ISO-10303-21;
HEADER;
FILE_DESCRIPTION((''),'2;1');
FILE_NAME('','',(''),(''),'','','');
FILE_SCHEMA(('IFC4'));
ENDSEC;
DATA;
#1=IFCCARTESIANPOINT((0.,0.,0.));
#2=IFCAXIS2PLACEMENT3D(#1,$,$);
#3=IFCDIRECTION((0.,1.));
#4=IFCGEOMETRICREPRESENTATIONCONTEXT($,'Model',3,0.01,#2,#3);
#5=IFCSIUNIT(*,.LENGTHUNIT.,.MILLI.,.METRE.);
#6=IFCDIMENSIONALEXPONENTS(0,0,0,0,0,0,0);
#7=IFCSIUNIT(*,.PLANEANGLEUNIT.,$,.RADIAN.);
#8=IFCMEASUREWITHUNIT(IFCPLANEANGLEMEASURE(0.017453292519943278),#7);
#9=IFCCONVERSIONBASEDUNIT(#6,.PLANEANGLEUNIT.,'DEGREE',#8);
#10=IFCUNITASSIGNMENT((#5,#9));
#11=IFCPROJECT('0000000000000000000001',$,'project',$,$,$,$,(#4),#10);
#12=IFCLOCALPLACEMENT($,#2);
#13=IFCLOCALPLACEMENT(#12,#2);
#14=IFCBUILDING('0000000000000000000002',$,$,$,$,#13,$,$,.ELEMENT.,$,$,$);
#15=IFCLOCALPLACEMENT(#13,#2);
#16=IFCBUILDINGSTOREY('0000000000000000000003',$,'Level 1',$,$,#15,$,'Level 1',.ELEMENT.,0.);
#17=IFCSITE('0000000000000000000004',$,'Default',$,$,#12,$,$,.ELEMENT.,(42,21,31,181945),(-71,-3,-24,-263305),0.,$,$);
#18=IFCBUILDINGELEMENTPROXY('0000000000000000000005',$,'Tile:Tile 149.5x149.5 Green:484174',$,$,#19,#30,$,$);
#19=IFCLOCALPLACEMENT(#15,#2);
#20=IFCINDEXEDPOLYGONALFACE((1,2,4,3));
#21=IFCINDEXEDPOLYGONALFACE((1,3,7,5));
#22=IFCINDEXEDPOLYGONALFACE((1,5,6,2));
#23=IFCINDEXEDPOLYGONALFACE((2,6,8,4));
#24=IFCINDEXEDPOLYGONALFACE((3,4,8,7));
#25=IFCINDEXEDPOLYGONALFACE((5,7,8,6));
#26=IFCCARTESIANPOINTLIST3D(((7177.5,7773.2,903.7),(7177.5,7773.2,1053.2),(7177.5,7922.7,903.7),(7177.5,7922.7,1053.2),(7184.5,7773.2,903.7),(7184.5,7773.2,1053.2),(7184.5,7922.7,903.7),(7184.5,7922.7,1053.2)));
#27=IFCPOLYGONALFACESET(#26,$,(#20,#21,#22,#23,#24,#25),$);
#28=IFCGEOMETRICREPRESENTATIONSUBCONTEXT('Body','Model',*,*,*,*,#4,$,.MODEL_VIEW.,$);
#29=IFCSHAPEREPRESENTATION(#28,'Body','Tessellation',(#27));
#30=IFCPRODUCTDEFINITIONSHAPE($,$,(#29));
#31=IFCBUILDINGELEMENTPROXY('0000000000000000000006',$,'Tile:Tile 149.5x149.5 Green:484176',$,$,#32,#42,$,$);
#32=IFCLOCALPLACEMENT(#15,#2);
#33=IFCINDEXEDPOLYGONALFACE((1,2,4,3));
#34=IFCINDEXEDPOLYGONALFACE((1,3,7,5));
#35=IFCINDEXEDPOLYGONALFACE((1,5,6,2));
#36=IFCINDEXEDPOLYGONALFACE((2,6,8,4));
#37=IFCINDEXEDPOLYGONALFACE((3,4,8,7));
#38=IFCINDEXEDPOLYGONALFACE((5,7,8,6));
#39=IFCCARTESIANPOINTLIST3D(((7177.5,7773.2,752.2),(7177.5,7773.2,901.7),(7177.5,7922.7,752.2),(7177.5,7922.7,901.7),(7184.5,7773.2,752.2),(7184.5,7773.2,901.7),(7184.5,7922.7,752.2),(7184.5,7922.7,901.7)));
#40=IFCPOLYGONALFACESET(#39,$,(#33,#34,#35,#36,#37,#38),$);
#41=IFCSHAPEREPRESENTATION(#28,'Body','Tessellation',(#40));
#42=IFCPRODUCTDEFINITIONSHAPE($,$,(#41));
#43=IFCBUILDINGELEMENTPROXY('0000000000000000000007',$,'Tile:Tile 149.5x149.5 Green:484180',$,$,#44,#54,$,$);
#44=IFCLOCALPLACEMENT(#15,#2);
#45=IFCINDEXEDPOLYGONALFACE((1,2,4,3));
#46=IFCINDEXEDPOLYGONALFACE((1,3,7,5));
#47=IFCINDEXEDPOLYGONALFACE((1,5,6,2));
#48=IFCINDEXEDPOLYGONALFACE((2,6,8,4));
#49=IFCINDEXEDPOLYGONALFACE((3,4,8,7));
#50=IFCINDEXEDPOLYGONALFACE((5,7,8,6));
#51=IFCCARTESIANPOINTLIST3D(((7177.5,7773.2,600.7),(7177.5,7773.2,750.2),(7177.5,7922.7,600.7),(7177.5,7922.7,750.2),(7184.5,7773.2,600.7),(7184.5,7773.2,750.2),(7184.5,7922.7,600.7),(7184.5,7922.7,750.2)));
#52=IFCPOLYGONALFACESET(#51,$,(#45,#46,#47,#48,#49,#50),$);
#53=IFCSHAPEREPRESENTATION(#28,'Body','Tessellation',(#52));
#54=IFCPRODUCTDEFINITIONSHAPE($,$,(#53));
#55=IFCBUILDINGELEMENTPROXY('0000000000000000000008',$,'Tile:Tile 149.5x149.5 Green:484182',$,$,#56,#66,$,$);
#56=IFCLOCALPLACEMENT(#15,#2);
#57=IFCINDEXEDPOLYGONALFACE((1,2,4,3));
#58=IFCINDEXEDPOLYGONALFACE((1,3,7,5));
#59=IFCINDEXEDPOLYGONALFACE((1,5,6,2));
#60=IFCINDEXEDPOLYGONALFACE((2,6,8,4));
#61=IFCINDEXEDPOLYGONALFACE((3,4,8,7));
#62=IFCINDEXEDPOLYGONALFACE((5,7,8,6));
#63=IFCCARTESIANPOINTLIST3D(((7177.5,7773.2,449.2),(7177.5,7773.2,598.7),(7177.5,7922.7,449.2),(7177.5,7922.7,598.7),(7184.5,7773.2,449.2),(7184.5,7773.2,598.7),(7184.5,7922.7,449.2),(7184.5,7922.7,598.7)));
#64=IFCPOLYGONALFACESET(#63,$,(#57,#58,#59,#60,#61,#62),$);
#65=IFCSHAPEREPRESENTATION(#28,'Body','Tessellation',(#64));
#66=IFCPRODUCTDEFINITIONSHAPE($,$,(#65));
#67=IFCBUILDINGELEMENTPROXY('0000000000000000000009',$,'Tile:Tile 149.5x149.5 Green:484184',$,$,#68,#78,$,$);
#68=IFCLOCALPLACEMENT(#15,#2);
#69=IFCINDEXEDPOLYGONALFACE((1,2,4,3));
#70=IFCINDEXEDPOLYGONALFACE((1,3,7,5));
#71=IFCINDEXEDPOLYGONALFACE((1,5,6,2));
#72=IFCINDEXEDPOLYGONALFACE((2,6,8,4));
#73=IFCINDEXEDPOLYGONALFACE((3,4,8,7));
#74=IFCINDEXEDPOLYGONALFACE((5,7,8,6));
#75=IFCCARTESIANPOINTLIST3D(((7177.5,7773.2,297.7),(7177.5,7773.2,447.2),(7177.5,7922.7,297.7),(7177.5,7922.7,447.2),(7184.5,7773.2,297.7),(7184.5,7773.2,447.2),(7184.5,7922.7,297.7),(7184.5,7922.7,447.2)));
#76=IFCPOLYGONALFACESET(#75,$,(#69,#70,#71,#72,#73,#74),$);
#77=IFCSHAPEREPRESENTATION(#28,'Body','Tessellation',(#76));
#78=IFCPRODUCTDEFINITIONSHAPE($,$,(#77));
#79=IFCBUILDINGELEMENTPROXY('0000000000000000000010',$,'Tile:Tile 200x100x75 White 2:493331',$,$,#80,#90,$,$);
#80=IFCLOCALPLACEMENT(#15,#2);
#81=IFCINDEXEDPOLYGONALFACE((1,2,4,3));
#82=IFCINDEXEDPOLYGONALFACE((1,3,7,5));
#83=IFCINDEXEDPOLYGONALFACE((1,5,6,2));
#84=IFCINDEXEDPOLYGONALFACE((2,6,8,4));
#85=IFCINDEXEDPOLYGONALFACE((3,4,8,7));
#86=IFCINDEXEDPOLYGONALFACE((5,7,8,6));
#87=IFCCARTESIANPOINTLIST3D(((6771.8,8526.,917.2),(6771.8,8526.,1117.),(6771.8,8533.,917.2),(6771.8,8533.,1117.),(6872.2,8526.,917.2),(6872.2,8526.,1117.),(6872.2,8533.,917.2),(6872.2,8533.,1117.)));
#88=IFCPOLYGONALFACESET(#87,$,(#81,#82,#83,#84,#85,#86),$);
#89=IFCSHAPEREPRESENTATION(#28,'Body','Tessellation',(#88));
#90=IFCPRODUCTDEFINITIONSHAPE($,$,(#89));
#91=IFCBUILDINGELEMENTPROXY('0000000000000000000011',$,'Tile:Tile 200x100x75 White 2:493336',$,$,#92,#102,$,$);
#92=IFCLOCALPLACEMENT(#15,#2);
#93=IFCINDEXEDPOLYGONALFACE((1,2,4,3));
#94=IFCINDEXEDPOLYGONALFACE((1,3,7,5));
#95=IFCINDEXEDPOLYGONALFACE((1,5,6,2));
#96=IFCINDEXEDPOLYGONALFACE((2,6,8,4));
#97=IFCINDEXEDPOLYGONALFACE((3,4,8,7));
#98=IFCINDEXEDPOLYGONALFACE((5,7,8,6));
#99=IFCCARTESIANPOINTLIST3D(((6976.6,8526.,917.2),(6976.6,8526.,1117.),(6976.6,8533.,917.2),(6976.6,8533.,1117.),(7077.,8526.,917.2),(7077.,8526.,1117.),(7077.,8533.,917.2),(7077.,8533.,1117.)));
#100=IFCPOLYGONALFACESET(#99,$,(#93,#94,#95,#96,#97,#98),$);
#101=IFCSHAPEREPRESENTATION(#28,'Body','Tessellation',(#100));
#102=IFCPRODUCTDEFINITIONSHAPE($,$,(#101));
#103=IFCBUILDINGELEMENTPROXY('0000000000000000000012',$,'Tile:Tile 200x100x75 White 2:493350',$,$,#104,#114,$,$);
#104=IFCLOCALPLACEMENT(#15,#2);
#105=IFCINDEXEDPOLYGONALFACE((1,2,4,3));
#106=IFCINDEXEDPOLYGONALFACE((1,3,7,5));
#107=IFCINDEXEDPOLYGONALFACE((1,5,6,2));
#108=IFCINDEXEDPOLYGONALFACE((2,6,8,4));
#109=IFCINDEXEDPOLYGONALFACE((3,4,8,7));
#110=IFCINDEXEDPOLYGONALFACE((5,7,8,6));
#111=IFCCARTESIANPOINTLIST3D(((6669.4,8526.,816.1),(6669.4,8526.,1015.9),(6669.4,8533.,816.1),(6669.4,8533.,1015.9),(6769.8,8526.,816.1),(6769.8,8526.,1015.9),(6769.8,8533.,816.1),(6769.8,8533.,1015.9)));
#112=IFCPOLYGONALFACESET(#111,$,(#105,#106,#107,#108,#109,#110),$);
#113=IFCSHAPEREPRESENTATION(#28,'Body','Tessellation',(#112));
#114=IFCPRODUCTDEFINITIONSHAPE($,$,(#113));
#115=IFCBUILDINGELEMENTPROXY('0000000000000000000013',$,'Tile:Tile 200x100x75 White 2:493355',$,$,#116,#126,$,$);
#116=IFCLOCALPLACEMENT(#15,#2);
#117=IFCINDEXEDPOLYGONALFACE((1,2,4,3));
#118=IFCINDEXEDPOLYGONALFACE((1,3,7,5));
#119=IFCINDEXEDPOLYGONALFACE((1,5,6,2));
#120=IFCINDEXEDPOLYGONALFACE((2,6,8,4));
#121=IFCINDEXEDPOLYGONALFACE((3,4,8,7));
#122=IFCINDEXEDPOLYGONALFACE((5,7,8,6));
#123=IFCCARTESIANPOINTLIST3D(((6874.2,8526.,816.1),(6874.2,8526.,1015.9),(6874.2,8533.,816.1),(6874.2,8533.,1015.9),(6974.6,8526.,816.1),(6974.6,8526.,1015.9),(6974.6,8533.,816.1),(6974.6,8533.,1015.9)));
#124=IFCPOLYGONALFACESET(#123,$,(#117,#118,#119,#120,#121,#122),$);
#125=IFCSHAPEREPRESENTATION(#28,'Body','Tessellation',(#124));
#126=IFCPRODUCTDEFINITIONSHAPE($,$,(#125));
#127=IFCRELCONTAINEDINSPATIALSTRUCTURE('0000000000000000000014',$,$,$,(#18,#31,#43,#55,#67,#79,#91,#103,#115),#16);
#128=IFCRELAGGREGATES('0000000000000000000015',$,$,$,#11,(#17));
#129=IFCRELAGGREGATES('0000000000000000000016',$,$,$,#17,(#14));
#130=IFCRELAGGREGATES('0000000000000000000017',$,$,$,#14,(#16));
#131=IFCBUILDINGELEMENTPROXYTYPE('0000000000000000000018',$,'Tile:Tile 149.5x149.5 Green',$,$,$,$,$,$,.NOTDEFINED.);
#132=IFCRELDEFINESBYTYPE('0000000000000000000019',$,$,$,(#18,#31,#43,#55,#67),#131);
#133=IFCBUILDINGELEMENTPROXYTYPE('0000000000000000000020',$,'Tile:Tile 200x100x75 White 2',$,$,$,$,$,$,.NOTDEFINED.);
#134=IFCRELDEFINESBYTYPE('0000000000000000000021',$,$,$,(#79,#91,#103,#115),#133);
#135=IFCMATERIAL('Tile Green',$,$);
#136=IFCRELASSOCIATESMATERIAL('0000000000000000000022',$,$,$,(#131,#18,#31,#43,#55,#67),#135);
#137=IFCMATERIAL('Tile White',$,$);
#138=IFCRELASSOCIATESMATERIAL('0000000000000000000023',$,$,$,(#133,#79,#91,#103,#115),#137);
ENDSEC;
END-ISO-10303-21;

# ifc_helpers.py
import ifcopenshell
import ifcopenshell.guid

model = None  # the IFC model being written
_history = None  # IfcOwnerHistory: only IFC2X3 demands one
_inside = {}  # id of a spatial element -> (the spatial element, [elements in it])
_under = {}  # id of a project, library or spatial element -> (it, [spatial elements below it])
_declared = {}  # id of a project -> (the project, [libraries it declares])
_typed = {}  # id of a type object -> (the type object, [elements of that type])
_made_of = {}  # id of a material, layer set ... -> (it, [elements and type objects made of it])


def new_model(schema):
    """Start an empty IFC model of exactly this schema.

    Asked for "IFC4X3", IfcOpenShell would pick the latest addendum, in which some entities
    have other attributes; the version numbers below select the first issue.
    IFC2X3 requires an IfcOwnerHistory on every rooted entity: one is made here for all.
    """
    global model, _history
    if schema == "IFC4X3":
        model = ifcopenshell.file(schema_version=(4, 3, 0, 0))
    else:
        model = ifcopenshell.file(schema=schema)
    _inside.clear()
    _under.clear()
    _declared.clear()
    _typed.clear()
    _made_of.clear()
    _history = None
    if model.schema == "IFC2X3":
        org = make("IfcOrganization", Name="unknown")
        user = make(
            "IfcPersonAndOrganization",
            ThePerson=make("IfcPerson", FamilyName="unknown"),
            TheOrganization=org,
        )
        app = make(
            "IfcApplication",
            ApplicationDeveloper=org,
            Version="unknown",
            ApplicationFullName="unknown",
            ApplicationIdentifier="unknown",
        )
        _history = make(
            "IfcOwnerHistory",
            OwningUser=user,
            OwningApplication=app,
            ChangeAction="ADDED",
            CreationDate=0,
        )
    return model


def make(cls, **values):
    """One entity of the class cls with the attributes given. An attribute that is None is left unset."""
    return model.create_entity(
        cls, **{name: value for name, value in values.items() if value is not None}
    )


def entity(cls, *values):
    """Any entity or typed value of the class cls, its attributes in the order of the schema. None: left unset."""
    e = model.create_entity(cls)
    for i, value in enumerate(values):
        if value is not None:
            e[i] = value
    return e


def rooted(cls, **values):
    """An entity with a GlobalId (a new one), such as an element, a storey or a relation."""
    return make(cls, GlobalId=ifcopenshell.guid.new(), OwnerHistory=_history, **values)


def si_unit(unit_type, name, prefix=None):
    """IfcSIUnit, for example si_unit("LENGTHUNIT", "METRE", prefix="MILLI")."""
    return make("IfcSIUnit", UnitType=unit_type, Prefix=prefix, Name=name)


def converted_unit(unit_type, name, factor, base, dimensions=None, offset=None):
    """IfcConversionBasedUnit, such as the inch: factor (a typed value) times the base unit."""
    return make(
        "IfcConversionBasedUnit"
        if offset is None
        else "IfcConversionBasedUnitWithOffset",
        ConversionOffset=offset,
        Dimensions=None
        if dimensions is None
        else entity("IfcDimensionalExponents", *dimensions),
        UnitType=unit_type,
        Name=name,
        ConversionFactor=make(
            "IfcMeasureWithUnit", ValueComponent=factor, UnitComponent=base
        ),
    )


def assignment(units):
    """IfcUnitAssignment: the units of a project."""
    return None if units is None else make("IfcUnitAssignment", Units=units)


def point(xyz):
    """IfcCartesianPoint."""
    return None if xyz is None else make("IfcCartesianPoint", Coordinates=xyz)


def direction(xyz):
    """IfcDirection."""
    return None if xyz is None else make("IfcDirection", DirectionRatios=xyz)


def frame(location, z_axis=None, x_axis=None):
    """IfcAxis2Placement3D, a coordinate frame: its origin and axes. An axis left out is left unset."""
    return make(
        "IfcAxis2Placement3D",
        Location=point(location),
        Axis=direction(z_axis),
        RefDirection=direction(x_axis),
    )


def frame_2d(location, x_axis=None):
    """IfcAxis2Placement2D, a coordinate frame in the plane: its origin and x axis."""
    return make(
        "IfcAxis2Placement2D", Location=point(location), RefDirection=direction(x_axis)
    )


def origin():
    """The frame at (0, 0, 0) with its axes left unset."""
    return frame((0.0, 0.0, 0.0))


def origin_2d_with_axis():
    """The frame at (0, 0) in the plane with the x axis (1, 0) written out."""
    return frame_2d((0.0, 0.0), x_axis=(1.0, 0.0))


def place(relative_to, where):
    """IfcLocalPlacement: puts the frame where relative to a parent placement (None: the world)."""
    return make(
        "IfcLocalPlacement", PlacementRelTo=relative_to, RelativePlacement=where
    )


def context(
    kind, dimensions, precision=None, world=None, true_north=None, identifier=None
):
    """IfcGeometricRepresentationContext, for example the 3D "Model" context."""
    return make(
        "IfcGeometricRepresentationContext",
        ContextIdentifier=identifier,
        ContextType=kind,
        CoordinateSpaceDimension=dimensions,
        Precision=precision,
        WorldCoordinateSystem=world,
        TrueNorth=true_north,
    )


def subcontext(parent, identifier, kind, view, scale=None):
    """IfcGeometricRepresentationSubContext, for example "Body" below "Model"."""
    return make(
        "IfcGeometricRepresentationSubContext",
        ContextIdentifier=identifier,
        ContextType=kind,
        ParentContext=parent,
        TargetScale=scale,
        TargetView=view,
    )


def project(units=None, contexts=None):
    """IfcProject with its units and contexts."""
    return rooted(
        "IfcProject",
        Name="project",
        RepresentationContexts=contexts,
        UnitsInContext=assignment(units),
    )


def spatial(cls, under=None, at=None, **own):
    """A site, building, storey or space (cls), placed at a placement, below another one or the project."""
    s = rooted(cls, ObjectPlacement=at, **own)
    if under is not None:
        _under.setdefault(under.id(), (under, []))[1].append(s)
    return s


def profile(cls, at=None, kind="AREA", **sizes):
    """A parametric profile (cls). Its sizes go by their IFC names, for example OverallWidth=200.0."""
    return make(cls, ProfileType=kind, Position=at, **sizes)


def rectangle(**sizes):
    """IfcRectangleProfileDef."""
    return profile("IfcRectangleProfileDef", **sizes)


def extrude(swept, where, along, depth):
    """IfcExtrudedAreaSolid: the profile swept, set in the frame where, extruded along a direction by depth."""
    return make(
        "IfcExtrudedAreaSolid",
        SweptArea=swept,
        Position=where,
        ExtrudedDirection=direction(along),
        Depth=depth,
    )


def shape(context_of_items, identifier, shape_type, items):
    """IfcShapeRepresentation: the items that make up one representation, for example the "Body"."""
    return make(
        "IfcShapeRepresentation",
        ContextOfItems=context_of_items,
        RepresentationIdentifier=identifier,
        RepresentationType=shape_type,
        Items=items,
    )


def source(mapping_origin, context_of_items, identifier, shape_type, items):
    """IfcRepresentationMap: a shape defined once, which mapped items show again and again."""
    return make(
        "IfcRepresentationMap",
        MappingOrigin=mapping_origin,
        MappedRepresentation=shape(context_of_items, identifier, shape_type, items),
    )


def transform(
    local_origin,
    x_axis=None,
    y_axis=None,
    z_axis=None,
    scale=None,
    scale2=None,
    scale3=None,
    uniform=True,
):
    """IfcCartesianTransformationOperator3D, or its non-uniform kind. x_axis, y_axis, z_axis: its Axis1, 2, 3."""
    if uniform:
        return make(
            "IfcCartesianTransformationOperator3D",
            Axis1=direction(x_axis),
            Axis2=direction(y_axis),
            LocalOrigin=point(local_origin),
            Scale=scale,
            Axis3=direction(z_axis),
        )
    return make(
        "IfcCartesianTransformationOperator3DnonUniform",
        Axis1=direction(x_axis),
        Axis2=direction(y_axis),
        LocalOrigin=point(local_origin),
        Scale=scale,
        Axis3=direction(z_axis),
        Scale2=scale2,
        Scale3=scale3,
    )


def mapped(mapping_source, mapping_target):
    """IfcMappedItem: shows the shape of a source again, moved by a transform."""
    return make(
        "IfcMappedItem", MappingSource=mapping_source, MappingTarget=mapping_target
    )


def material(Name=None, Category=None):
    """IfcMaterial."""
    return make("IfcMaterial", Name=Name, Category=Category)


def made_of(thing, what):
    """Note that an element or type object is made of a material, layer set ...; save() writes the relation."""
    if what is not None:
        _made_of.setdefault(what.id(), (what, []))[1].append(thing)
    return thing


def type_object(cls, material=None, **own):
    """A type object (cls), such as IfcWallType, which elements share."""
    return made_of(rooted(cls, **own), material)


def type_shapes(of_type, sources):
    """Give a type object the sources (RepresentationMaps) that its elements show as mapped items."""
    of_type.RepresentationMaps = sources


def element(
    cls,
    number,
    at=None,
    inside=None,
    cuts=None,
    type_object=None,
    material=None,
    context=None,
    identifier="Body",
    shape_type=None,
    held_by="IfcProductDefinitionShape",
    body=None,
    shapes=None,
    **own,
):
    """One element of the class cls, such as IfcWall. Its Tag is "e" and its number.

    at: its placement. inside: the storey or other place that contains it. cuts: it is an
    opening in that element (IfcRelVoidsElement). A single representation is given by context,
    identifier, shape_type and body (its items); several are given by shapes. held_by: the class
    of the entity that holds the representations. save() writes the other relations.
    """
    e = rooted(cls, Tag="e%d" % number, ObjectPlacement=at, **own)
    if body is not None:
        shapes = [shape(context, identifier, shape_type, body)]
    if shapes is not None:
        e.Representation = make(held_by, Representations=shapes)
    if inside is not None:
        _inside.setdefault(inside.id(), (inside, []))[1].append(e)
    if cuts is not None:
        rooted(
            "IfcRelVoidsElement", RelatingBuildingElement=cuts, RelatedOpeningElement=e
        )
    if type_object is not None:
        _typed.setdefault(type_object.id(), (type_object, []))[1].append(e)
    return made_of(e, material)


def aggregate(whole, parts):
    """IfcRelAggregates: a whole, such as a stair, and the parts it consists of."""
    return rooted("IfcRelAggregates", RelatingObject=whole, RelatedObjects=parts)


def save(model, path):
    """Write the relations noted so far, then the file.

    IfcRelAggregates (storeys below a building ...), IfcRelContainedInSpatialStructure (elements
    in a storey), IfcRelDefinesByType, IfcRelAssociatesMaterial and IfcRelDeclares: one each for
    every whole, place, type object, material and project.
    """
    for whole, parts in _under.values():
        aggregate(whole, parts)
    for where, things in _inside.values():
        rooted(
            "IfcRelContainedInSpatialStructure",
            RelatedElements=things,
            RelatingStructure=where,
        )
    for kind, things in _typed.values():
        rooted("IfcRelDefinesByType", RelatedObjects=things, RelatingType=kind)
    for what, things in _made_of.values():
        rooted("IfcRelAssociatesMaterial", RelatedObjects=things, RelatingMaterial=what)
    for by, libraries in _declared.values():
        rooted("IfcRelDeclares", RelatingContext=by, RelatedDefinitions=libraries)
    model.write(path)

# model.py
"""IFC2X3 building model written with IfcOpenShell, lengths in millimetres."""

from ifc_helpers import new_model, entity, si_unit, converted_unit, direction, frame, frame_2d, origin, origin_2d_with_axis, place, context, subcontext, project, spatial, rectangle, extrude, source, transform, mapped, material, type_object, type_shapes, element, save


model = new_model("IFC2X3")

# Units and contexts
model_context = context("Model", 3, precision=0.01, world=origin(), true_north=direction((0.0, 1.0)))
body_context = subcontext(model_context, "Body", "Model", "MODEL_VIEW")
ifc_project = project(units=[si_unit("LENGTHUNIT", "METRE", prefix="MILLI"), converted_unit("PLANEANGLEUNIT", "DEGREE", entity("IfcPlaneAngleMeasure", 0.017453292519943278), si_unit("PLANEANGLEUNIT", "RADIAN"), dimensions=[0, 0, 0, 0, 0, 0, 0])], contexts=[model_context])

# Site, building, storey
site_placement = place(None, origin())
site = spatial("IfcSite", under=ifc_project, at=site_placement, Name="Default", CompositionType="ELEMENT", RefLatitude=(42, 21, 31, 181945), RefLongitude=(-71, -3, -24, -263305), RefElevation=0.0)
building_placement = place(site_placement, origin())
building = spatial("IfcBuilding", under=site, at=building_placement, CompositionType="ELEMENT")
storey_placement = place(building_placement, origin())
storey = spatial("IfcBuildingStorey", under=building, at=storey_placement, Name="Level 1", LongName="Level 1", CompositionType="ELEMENT", Elevation=0.0)

# Building element proxies
ifc_material_1 = material(Name="Tile White")
ifc_material_2 = material(Name="Tile Green")
building_element_proxy_type_1 = type_object("IfcBuildingElementProxyType", Name="Tile:Tile 149.5x149.5 Green", PredefinedType="NOTDEFINED", material=ifc_material_2)
shared_shape_1 = source(origin(), body_context, "Body", "SweptSolid", [
    extrude(rectangle(XDim=149.5, YDim=149.5, at=origin_2d_with_axis()), frame((-74.7, -74.8, 0.0), z_axis=(0.0, 0.0, 1.0), x_axis=(0.0, -1.0, 0.0)), (0.0, 0.0, 1.0), 7.0),
])
type_shapes(building_element_proxy_type_1, [shared_shape_1])
for number, where, z_axis, x_axis, name in (
    (1, (7184.5, 7922.7, 1053.2), (-1.0, 0.0, 0.0), (0.0, 0.0, 1.0), "Tile:Tile 149.5x149.5 Green:484174"),
    (2, (7184.5, 7922.7, 901.7), (-1.0, 0.0, 0.0), (0.0, 0.0, 1.0), "Tile:Tile 149.5x149.5 Green:484176"),
    (3, (7184.5, 7922.7, 750.2), (-1.0, 0.0, 0.0), (0.0, 0.0, 1.0), "Tile:Tile 149.5x149.5 Green:484180"),
    (4, (7184.5, 7922.7, 598.7), (-1.0, 0.0, 0.0), (0.0, 0.0, 1.0), "Tile:Tile 149.5x149.5 Green:484182"),
    (5, (7184.5, 7922.7, 447.2), (-1.0, 0.0, 0.0), (0.0, 0.0, 1.0), "Tile:Tile 149.5x149.5 Green:484184"),
):
    element("IfcBuildingElementProxy", number, at=place(storey_placement, frame(where, z_axis=z_axis, x_axis=x_axis)), inside=storey, type_object=building_element_proxy_type_1, material=ifc_material_2, Name=name, context=body_context, shape_type="MappedRepresentation", body=[
        mapped(shared_shape_1, transform((0.0, 0.0, 0.0), scale=1.0)),
    ])
building_element_proxy_type_2 = type_object("IfcBuildingElementProxyType", Name="Tile:Tile 200x100x75 White 2", PredefinedType="NOTDEFINED", material=ifc_material_1)
shared_shape_2 = source(origin(), body_context, "Body", "SweptSolid", [
    extrude(rectangle(XDim=199.8, YDim=100.4, at=frame_2d((0.0, 0.0), x_axis=(1.0, 0.0))), frame((-50.2, -99.9, 0.0), z_axis=(0.0, 0.0, 1.0), x_axis=(0.0, -1.0, 0.0)), (0.0, 0.0, 1.0), 7.0),
])
type_shapes(building_element_proxy_type_2, [shared_shape_2])
for number, where, z_axis, x_axis, name in (
    (6, (6872.2, 8533.0, 1117.0), (0.0, -1.0, 0.0), (1.0, 0.0, 0.0), "Tile:Tile 200x100x75 White 2:493331"),
    (7, (7077.0, 8533.0, 1117.0), (0.0, -1.0, 0.0), (1.0, 0.0, 0.0), "Tile:Tile 200x100x75 White 2:493336"),
    (8, (6769.8, 8533.0, 1015.9), (0.0, -1.0, 0.0), (1.0, 0.0, 0.0), "Tile:Tile 200x100x75 White 2:493350"),
    (9, (6974.6, 8533.0, 1015.9), (0.0, -1.0, 0.0), (1.0, 0.0, 0.0), "Tile:Tile 200x100x75 White 2:493355"),
):
    element("IfcBuildingElementProxy", number, at=place(storey_placement, frame(where, z_axis=z_axis, x_axis=x_axis)), inside=storey, type_object=building_element_proxy_type_2, material=ifc_material_1, Name=name, context=body_context, shape_type="MappedRepresentation", body=[
        mapped(shared_shape_2, transform((0.0, 0.0, 0.0), scale=1.0)),
    ])

save(model, "model.ifc")
